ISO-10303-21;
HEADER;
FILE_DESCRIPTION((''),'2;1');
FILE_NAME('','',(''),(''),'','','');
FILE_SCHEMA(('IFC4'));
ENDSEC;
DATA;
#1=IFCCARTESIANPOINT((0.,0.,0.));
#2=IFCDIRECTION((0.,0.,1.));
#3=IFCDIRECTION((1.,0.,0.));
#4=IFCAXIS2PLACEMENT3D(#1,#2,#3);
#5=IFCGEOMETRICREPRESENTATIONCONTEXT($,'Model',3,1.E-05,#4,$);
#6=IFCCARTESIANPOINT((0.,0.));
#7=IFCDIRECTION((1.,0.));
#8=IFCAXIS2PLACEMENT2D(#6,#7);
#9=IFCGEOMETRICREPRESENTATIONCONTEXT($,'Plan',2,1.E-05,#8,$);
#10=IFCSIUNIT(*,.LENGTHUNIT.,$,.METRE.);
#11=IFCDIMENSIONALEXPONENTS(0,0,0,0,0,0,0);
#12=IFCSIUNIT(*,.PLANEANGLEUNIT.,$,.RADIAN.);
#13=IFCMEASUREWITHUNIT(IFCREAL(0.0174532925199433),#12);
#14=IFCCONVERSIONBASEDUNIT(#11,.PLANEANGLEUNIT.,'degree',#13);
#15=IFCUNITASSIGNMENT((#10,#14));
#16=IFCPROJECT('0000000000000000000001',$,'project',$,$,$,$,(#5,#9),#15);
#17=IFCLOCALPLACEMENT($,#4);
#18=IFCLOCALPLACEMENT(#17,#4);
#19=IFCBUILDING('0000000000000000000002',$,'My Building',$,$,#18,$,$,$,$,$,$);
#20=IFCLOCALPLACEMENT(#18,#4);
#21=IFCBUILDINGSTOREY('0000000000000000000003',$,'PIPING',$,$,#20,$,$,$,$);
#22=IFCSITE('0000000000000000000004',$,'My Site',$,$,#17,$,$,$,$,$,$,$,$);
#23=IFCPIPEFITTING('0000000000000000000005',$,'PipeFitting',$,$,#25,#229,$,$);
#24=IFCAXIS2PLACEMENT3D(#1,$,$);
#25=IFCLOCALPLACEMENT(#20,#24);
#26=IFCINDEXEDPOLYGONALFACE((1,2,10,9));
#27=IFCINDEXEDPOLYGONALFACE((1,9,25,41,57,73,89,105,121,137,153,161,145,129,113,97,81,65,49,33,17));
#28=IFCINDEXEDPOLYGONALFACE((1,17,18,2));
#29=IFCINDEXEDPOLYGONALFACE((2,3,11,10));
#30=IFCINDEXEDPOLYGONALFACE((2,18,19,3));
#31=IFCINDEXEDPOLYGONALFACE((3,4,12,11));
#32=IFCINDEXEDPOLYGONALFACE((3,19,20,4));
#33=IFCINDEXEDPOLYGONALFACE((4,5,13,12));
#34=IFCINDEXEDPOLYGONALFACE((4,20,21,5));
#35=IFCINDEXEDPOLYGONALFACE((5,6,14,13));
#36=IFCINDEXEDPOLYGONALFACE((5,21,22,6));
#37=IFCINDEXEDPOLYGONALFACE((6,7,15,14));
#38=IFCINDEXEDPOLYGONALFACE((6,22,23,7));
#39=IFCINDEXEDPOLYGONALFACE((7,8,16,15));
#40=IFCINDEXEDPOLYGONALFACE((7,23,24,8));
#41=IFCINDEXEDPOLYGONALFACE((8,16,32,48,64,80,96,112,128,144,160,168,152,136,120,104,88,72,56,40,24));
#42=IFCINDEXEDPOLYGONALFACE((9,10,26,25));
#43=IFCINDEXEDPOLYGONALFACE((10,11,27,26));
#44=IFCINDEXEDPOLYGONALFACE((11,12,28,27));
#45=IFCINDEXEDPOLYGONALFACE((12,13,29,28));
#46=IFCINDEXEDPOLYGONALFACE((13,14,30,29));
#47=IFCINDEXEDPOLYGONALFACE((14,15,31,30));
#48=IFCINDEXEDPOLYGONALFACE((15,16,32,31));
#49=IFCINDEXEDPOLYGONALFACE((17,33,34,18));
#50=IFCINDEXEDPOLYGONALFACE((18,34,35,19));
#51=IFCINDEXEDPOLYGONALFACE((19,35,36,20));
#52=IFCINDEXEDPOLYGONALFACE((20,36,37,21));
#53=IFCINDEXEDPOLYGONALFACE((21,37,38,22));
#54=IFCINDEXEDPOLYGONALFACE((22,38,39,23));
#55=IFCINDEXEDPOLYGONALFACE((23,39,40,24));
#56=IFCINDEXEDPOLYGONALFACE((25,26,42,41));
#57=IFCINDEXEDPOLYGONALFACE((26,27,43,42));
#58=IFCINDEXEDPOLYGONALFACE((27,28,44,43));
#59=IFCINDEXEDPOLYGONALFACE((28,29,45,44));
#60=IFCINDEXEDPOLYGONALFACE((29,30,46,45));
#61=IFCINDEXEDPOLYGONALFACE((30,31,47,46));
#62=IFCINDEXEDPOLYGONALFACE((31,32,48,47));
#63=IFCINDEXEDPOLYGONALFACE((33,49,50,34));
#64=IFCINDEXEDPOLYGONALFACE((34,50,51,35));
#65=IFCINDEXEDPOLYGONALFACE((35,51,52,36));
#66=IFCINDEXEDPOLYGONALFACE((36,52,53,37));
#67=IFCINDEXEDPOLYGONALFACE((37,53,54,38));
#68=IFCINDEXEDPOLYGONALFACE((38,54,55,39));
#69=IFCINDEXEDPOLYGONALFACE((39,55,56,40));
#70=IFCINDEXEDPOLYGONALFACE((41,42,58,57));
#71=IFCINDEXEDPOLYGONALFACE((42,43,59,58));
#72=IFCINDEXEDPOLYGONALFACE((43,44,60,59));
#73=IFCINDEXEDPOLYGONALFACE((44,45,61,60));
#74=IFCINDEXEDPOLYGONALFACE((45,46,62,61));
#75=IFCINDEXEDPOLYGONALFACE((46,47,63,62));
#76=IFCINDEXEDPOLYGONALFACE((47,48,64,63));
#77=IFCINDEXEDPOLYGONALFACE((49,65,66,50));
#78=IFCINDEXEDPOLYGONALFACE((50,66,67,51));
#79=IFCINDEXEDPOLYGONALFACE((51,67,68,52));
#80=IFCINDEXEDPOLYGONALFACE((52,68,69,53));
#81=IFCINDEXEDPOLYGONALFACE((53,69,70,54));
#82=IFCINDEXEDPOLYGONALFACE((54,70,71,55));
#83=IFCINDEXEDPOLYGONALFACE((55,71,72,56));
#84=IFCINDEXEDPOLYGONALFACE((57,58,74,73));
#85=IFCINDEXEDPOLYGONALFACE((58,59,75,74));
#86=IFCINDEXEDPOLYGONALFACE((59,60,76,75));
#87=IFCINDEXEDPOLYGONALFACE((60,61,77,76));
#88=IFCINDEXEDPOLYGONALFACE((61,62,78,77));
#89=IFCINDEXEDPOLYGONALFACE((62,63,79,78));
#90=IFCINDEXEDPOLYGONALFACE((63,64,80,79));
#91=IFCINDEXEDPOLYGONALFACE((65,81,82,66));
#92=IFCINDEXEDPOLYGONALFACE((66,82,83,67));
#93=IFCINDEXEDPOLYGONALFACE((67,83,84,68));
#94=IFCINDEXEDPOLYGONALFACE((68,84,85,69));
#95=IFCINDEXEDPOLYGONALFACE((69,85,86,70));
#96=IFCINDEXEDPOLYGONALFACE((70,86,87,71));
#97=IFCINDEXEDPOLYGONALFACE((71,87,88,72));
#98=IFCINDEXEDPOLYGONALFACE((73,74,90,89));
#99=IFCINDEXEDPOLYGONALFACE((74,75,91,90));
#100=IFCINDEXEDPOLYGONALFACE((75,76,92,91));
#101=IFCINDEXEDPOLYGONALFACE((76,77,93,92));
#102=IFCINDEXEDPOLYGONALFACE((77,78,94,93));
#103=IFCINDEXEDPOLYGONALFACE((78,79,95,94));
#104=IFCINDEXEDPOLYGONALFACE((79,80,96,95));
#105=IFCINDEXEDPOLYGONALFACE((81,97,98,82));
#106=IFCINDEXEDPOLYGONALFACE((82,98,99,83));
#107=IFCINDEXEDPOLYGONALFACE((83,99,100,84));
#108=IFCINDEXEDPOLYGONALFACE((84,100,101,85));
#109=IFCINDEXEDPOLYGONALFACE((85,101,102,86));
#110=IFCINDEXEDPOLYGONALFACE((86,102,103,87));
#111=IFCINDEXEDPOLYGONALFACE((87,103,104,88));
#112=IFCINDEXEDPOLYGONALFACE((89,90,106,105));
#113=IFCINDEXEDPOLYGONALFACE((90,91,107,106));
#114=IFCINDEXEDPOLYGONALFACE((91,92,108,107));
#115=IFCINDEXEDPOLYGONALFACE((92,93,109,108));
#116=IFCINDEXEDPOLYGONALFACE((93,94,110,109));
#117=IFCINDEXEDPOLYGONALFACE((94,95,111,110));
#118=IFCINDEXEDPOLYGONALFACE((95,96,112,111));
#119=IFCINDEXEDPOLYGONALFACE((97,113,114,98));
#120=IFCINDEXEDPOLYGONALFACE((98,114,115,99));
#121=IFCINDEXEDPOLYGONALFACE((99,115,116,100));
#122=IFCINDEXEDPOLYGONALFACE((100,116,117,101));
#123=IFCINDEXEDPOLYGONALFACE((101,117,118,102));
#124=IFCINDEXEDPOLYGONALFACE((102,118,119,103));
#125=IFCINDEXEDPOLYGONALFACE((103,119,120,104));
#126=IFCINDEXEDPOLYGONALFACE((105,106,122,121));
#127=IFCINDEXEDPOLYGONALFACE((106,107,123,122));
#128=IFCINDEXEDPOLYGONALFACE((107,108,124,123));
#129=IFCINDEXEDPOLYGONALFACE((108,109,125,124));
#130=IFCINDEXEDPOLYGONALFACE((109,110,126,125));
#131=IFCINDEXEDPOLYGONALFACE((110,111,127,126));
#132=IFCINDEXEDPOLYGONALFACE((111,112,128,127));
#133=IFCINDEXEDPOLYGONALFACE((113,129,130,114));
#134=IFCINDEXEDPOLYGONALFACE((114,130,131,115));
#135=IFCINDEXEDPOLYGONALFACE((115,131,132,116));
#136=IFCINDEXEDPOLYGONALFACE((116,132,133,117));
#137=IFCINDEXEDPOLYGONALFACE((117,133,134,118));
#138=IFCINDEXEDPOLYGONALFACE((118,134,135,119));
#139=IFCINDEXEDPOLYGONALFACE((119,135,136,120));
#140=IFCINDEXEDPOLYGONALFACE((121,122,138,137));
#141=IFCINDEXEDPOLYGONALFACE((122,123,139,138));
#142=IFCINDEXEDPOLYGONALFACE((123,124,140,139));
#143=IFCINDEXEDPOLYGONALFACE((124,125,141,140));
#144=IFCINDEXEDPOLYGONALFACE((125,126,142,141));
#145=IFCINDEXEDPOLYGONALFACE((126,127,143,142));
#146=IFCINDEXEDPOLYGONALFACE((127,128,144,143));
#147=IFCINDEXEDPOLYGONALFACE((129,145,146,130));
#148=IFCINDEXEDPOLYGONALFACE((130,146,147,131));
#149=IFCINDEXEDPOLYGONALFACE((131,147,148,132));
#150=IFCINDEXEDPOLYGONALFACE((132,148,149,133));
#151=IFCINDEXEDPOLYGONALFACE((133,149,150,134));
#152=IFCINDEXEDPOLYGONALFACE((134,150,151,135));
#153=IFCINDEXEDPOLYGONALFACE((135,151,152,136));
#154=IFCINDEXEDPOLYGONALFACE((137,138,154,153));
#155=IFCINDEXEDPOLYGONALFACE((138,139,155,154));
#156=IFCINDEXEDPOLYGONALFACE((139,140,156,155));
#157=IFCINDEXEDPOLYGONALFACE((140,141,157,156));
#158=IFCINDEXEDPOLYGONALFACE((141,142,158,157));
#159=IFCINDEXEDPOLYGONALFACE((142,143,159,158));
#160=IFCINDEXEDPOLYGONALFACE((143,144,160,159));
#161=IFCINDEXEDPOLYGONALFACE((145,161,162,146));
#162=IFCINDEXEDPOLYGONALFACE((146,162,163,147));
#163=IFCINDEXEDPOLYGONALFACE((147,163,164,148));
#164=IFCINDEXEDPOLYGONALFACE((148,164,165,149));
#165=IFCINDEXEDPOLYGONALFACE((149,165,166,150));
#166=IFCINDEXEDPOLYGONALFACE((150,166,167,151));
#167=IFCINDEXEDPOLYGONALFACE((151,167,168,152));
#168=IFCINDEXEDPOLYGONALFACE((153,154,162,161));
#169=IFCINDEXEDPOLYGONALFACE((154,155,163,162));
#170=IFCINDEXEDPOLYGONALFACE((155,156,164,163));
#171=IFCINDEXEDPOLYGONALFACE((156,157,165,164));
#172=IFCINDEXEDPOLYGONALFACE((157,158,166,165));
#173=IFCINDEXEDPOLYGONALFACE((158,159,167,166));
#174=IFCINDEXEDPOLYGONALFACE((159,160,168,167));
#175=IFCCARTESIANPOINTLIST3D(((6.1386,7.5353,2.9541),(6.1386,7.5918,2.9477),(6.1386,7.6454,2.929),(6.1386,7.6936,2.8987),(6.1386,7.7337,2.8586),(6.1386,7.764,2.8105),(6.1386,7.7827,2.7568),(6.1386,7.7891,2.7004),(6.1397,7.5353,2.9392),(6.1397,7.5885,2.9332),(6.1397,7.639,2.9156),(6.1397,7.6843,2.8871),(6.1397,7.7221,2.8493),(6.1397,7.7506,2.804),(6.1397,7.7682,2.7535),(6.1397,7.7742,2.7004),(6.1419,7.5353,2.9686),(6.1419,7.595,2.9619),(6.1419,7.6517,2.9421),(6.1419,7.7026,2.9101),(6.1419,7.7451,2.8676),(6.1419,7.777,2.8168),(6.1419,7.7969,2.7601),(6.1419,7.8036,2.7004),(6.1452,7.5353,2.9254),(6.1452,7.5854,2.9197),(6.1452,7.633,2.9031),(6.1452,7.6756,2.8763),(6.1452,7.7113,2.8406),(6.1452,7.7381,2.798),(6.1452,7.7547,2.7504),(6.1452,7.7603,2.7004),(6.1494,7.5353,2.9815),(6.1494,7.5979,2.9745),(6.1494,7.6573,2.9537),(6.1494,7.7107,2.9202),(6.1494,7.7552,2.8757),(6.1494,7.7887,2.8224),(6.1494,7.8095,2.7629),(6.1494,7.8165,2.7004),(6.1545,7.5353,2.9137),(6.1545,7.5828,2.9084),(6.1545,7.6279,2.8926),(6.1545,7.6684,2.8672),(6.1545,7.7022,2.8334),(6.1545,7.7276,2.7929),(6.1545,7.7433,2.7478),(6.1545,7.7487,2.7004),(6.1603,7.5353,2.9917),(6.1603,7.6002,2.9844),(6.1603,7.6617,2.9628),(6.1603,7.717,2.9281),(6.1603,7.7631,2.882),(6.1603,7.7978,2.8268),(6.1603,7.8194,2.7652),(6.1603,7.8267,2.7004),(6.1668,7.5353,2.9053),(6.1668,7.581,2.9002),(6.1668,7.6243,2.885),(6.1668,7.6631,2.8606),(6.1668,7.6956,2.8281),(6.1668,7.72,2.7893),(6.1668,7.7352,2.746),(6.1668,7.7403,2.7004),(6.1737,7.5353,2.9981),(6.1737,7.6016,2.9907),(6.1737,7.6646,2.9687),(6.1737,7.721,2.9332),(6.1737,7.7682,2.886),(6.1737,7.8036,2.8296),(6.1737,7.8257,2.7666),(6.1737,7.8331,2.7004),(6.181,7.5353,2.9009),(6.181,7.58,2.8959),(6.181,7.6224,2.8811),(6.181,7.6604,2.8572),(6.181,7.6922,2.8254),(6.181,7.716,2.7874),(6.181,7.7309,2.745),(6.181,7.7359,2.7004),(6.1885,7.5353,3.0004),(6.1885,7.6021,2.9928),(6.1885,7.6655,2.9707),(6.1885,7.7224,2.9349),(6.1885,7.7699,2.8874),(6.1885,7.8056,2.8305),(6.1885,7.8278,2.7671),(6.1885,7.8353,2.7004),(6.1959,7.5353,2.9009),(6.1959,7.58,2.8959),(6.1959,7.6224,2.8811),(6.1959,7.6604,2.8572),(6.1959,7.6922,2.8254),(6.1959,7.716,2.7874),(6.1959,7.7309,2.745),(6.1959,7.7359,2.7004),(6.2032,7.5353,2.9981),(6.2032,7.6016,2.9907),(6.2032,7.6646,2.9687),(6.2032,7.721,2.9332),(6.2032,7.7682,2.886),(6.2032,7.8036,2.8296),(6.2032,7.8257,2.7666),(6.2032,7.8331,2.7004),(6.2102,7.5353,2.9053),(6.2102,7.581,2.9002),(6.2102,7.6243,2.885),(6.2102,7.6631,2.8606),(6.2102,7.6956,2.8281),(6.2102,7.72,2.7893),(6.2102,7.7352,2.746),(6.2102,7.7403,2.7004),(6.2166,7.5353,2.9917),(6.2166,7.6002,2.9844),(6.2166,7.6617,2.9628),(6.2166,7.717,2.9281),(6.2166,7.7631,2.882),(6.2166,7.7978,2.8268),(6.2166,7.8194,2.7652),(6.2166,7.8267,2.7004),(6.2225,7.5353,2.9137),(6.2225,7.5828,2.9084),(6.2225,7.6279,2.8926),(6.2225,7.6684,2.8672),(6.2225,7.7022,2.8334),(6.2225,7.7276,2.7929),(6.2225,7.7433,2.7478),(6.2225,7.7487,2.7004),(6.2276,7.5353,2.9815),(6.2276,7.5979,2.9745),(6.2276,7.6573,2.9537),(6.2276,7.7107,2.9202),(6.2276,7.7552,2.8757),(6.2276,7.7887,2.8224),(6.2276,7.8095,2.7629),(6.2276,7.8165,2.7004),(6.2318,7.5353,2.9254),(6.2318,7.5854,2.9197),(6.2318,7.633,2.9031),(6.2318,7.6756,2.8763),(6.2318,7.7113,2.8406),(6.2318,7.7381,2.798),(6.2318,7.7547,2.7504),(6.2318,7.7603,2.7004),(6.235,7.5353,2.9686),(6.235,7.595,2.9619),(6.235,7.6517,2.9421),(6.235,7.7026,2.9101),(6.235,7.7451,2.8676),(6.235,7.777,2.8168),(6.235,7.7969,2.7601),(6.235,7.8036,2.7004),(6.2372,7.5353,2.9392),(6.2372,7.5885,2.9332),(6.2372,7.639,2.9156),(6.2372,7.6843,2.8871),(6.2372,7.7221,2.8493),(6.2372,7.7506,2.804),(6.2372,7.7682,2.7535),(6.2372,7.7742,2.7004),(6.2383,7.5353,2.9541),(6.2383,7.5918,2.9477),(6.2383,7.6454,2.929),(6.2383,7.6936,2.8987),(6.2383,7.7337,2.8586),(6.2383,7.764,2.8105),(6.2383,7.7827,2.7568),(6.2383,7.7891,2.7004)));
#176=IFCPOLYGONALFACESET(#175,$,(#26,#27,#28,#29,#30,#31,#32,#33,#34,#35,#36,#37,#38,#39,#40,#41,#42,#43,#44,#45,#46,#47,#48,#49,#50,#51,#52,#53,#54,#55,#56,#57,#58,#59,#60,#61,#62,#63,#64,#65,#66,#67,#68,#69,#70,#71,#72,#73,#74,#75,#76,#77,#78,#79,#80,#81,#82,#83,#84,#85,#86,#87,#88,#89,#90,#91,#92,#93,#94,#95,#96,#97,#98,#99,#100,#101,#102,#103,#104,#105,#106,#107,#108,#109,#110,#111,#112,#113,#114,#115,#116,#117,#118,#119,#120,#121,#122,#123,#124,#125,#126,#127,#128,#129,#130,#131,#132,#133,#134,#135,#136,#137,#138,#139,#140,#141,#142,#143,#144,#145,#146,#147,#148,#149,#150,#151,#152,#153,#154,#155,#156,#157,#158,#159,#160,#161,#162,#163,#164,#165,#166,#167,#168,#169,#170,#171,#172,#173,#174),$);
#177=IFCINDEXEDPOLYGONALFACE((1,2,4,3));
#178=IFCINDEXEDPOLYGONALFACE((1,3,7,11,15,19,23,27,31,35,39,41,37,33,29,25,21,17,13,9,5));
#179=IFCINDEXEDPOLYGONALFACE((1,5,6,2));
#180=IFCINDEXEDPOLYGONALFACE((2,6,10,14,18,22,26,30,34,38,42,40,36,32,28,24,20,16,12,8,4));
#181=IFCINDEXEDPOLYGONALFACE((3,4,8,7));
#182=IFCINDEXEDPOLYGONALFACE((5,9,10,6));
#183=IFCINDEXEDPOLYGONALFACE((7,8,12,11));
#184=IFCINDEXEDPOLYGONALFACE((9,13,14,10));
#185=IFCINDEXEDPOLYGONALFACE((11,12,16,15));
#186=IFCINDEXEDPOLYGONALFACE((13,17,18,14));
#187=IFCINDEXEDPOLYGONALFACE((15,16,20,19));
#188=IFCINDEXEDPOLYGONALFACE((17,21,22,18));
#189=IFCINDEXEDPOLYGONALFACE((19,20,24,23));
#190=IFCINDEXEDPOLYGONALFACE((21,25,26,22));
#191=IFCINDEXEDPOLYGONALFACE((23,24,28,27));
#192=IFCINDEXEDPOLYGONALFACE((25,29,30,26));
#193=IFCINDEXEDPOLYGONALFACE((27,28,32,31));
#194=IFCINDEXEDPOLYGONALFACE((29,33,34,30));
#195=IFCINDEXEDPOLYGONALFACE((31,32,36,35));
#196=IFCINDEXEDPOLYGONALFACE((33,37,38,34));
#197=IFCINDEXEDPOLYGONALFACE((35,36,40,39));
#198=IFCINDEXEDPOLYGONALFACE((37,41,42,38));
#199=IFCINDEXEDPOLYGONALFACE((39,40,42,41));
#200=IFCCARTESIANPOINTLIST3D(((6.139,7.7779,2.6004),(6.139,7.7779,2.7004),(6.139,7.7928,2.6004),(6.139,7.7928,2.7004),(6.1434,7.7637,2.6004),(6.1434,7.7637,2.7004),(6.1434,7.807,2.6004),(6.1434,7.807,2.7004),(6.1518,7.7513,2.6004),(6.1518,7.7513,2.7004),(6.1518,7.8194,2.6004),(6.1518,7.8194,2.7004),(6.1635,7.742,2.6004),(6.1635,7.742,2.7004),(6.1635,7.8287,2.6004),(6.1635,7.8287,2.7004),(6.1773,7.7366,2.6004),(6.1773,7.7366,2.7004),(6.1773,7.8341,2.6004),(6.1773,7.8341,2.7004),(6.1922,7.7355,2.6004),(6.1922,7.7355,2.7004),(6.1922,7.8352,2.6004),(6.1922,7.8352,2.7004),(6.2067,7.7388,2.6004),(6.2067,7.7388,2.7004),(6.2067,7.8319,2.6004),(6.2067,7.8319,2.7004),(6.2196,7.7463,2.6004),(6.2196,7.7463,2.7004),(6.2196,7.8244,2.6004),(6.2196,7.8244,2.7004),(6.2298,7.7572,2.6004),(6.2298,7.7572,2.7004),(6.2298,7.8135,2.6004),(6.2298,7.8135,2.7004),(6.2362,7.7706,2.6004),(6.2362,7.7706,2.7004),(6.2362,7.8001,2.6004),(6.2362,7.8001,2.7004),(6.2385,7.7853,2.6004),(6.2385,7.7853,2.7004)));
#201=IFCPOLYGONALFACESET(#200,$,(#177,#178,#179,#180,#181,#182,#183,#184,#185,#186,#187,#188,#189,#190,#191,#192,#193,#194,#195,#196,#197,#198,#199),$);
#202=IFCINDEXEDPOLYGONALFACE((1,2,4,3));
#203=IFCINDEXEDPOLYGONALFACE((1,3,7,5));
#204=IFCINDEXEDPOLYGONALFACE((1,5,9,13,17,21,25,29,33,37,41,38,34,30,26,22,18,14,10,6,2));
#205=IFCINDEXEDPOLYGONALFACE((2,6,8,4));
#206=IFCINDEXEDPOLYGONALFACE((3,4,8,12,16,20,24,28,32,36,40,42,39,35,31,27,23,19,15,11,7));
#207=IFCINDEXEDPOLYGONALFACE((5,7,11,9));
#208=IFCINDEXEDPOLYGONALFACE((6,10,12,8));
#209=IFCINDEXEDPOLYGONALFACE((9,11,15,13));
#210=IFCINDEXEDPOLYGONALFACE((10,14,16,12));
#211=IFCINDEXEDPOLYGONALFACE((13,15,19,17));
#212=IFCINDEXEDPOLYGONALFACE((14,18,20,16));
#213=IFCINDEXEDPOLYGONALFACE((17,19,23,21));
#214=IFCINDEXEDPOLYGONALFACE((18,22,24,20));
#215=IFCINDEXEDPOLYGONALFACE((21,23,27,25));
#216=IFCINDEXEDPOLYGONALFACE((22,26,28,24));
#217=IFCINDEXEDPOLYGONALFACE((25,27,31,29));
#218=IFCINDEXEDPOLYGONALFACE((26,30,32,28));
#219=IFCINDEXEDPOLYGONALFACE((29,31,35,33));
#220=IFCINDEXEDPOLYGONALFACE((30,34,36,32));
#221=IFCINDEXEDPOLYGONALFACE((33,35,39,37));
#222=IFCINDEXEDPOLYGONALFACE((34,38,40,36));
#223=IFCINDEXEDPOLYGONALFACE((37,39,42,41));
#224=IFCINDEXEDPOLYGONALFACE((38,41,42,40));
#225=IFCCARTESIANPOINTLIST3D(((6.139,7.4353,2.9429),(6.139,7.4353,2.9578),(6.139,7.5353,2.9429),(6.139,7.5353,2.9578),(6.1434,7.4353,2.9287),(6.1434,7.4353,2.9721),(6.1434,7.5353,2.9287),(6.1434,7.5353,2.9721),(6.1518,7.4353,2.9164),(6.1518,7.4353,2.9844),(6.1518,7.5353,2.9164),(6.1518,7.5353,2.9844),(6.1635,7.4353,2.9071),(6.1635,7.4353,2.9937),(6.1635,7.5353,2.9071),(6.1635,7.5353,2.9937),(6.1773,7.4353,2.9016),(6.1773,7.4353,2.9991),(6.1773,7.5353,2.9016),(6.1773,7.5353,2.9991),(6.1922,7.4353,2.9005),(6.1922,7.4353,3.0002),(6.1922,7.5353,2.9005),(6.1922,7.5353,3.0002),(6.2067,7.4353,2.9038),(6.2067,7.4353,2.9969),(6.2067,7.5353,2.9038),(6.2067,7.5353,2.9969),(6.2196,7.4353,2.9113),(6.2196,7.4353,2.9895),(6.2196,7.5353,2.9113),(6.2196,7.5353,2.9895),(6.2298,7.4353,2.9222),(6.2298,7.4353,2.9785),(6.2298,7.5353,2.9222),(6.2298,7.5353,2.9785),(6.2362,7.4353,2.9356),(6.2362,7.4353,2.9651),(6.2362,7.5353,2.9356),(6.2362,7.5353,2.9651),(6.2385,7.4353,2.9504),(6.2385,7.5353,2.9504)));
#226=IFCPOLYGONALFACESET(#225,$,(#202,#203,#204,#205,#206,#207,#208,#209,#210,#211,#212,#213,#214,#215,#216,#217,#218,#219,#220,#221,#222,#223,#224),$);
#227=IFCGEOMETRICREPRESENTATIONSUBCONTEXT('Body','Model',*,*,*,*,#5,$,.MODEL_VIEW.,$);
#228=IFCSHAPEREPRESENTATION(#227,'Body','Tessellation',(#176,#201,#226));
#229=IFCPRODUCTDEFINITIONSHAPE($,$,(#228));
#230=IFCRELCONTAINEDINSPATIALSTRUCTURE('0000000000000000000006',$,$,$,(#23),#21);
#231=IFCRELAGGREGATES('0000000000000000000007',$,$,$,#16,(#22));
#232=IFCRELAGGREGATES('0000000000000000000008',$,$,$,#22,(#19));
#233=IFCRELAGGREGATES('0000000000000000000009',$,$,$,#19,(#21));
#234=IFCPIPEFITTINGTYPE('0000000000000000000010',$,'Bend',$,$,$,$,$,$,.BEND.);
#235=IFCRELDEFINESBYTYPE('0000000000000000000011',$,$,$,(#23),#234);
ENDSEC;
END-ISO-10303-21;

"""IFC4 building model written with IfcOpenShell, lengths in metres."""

from ifc_helpers import new_model, entity, si_unit, converted_unit, frame, origin_with_axes, origin_2d_with_axis, place, context, subcontext, project, spatial, circle, extrude, source, transform, mapped, type_object, type_shapes, element, save


model = new_model("IFC4")

# Units and contexts
model_context = context("Model", 3, precision=1e-05, world=origin_with_axes())
plan_context = context("Plan", 2, precision=1e-05, world=origin_2d_with_axis())
body_context = subcontext(model_context, "Body", "Model", "MODEL_VIEW")
ifc_project = project(units=[si_unit("LENGTHUNIT", "METRE"), converted_unit("PLANEANGLEUNIT", "degree", entity("IfcReal", 0.0174532925199433), si_unit("PLANEANGLEUNIT", "RADIAN"), dimensions=[0, 0, 0, 0, 0, 0, 0])], contexts=[model_context, plan_context])

# Site, building, storey
site_placement = place(None, origin_with_axes())
site = spatial("IfcSite", under=ifc_project, at=site_placement, Name="My Site")
building_placement = place(site_placement, origin_with_axes())
building = spatial("IfcBuilding", under=site, at=building_placement, Name="My Building")
storey_placement = place(building_placement, origin_with_axes())
storey = spatial("IfcBuildingStorey", under=building, at=storey_placement, Name="PIPING")

# Pipe fitting
pipe_fitting_type_1 = type_object("IfcPipeFittingType", Name="Bend", PredefinedType="BEND")
shared_shape = source(origin_with_axes(), body_context, "Body", "SolidModel", [
    entity("IfcSweptDiskSolid", entity("IfcIndexedPolyCurve", entity("IfcCartesianPointList3D", [[0.0, 0.0, -0.1], [0.0, 0.0732, -0.2768], [0.0, 0.25, -0.35]]), [entity("IfcArcIndex", [1, 2, 3])]), 0.05),
    extrude(circle(Radius=0.05), origin_with_axes(), (0.0, 0.0, -1.0), 0.1),
    extrude(circle(Radius=0.05), frame((0.0, 0.25, -0.35), z_axis=(0.0, 1.0, 0.0), x_axis=(1.0, 0.0, 0.0)), (0.0, 0.0, 1.0), 0.1),
])
type_shapes(pipe_fitting_type_1, [shared_shape])
for number, where, z_axis, x_axis, name in (
    (1, (6.1885, 7.7853, 2.6004), (0.0, 0.0, -1.0), (1.0, 0.0, 0.0), "PipeFitting"),
):
    element("IfcPipeFitting", number, at=place(storey_placement, frame(where, z_axis=z_axis, x_axis=x_axis)), inside=storey, type_object=pipe_fitting_type_1, Name=name, context=body_context, shape_type="MappedRepresentation", body=[
        mapped(shared_shape, transform((0.0, 0.0, 0.0), x_axis=(1.0, 0.0, 0.0), y_axis=(0.0, 1.0, 0.0), z_axis=(0.0, 0.0, 1.0), scale=1.0)),
    ])

save(model, "model.ifc")
